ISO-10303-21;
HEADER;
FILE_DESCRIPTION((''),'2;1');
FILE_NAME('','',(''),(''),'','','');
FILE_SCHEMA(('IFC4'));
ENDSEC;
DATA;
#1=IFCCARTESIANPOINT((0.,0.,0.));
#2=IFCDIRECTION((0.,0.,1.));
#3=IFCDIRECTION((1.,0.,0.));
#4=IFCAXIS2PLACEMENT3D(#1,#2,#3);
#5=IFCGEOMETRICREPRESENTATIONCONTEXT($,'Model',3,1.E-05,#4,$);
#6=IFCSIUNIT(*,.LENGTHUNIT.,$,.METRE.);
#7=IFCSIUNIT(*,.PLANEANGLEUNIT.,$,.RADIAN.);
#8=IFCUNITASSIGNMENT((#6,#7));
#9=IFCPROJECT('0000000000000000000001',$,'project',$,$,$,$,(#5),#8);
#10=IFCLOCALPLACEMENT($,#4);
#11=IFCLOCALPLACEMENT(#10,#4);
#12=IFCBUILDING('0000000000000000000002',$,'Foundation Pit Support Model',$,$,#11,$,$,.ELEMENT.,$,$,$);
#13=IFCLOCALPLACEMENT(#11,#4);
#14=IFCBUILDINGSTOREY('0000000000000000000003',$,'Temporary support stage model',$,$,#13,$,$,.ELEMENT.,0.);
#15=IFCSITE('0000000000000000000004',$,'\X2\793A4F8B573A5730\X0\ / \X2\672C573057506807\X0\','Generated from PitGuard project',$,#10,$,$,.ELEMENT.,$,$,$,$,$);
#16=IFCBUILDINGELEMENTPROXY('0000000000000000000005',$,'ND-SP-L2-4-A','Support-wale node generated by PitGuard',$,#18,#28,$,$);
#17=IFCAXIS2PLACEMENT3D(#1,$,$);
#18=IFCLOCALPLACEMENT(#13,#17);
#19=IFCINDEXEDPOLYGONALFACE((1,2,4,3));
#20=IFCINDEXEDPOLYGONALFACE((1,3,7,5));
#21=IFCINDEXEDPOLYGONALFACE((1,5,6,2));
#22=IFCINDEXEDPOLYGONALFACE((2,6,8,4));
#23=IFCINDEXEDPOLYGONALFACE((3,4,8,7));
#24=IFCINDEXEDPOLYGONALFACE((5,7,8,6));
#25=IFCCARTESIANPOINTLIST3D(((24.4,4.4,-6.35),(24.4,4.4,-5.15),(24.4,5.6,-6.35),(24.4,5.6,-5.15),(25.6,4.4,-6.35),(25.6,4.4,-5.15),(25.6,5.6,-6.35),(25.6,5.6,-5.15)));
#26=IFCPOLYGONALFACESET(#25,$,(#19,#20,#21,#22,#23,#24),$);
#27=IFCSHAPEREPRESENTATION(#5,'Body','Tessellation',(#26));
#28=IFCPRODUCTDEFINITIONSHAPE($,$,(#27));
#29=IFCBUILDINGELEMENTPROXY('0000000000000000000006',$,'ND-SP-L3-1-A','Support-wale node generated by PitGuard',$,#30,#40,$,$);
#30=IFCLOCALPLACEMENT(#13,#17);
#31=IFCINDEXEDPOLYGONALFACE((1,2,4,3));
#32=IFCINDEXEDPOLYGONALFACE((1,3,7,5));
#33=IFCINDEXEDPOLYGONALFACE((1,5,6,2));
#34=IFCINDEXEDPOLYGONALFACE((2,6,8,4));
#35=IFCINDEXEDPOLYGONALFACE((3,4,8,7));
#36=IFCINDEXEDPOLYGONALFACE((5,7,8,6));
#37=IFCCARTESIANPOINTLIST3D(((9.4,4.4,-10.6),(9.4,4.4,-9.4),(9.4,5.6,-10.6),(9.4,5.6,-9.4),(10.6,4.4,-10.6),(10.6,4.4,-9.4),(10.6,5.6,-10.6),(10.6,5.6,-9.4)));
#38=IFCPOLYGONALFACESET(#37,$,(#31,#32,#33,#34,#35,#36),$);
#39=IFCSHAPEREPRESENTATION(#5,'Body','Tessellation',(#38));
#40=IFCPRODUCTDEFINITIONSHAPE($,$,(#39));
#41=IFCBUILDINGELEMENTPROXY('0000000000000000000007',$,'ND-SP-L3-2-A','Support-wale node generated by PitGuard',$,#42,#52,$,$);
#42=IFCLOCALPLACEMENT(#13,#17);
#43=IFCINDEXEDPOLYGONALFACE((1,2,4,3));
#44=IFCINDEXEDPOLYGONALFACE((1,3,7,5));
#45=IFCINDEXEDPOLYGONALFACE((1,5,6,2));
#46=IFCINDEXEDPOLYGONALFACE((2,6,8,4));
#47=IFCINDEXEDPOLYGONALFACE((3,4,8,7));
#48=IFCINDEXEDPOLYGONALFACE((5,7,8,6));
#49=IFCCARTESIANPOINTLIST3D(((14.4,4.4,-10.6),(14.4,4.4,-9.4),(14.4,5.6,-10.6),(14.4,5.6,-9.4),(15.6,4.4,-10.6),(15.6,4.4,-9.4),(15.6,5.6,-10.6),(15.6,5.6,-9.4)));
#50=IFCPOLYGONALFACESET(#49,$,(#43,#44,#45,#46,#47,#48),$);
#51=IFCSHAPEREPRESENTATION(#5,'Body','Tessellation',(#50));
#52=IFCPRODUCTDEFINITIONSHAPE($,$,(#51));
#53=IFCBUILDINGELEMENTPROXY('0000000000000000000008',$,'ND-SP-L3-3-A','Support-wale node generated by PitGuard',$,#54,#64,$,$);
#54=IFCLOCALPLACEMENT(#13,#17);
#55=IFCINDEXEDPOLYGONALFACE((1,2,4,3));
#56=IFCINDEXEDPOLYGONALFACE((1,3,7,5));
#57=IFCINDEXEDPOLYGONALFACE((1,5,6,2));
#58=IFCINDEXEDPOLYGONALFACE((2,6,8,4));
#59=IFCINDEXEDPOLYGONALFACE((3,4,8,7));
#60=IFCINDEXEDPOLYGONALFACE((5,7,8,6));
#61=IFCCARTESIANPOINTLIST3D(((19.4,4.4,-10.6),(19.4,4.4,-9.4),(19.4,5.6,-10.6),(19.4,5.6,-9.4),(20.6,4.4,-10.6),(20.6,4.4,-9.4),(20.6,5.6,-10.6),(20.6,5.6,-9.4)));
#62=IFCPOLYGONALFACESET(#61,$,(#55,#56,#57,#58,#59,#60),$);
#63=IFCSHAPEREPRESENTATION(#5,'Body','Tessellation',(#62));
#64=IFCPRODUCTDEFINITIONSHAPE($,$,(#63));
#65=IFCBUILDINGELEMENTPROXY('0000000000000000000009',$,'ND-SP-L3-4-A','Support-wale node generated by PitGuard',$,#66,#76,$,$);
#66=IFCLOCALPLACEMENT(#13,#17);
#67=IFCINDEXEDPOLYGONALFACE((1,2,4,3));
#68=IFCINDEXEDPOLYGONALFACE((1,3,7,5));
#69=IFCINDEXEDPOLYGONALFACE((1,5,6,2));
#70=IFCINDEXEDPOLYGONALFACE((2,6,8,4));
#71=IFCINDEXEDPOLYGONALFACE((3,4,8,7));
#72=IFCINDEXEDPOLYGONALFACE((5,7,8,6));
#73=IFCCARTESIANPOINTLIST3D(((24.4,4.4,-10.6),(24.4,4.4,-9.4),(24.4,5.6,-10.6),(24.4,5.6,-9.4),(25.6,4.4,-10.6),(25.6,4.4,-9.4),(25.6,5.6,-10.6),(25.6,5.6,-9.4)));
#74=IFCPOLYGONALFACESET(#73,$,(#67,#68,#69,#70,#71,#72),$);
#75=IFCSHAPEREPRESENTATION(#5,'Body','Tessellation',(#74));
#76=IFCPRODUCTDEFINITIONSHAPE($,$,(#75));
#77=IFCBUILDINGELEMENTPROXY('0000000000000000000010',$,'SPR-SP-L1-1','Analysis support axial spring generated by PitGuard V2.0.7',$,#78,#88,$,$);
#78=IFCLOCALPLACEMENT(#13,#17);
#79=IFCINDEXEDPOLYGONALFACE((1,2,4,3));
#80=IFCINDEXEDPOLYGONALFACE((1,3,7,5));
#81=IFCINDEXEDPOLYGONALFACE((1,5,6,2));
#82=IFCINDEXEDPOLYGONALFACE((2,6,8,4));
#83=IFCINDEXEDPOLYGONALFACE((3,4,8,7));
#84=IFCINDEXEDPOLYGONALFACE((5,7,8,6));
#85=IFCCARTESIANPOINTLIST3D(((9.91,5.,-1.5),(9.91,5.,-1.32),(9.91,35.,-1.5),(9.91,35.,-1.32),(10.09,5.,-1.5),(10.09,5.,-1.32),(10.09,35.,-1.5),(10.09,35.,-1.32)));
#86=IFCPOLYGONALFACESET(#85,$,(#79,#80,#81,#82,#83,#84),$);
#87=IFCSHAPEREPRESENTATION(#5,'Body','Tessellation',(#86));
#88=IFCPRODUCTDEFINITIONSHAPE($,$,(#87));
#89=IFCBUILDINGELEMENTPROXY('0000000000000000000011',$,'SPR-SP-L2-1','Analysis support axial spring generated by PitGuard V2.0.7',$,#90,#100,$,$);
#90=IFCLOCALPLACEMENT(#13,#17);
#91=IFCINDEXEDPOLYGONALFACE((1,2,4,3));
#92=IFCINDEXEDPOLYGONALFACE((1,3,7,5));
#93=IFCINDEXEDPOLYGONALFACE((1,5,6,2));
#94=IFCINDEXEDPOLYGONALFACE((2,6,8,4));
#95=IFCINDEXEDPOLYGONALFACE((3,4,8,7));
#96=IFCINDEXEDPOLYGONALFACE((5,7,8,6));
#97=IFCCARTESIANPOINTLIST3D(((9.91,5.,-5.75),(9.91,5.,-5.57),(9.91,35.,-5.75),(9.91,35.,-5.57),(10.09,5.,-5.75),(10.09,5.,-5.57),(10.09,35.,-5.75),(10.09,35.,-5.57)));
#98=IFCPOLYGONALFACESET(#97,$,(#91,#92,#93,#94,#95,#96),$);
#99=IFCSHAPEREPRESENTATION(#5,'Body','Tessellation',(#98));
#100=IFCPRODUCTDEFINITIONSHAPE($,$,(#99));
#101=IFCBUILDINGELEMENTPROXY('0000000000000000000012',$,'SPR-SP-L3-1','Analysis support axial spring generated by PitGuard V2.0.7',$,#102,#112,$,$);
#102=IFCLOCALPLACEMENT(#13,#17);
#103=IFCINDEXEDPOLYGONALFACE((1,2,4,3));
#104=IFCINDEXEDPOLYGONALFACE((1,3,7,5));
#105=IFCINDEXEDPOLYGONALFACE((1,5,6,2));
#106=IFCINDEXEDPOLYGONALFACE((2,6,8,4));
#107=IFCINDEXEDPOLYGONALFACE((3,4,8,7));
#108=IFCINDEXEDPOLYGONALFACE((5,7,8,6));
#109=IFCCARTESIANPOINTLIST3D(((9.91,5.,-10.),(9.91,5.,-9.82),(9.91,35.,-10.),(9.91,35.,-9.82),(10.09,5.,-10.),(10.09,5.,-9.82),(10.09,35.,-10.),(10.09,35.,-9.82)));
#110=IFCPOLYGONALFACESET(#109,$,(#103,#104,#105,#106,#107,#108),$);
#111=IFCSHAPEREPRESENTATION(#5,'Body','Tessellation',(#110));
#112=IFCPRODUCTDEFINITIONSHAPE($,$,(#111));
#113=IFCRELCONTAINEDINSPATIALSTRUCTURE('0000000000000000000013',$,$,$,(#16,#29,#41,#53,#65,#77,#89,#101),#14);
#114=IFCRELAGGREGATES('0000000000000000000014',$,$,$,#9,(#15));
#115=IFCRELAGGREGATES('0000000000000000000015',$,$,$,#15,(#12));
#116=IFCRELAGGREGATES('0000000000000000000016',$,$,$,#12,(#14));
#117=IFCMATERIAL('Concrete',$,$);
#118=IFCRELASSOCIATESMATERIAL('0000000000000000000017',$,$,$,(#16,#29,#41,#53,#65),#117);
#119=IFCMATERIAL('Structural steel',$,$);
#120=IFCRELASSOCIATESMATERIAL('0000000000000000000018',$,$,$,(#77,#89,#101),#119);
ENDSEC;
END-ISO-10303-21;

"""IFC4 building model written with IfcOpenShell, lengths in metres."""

from ifc_helpers import new_model, si_unit, frame, origin_with_axes, origin_2d, place, context, project, spatial, rectangle, extrude, material, element, save


model = new_model("IFC4")

# Units and contexts
model_context = context("Model", 3, precision=1e-05, world=origin_with_axes())
ifc_project = project(units=[si_unit("LENGTHUNIT", "METRE"), si_unit("PLANEANGLEUNIT", "RADIAN")], contexts=[model_context])

# Site, building, storey
site_placement = place(None, origin_with_axes())
site = spatial("IfcSite", under=ifc_project, at=site_placement, Name="示例场地 / 本地坐标", Description="Generated from PitGuard project", CompositionType="ELEMENT")
building_placement = place(site_placement, origin_with_axes())
building = spatial("IfcBuilding", under=site, at=building_placement, Name="Foundation Pit Support Model", CompositionType="ELEMENT")
storey_placement = place(building_placement, origin_with_axes())
storey = spatial("IfcBuildingStorey", under=building, at=storey_placement, Name="Temporary support stage model", CompositionType="ELEMENT", Elevation=0.0)

# Shared definitions
ifc_material_1 = material(Name="Structural steel")

# Shared definitions
ifc_material_2 = material(Name="Concrete")

# Building element proxies
for number, where, z_axis, x_axis, name in (
    (1, (25.0, 5.0, -6.35), (0.0, 0.0, 1.0), (1.0, 0.0, 0.0), "ND-SP-L2-4-A"),
    (2, (10.0, 5.0, -10.6), (0.0, 0.0, 1.0), (1.0, 0.0, 0.0), "ND-SP-L3-1-A"),
    (3, (15.0, 5.0, -10.6), (0.0, 0.0, 1.0), (1.0, 0.0, 0.0), "ND-SP-L3-2-A"),
    (4, (20.0, 5.0, -10.6), (0.0, 0.0, 1.0), (1.0, 0.0, 0.0), "ND-SP-L3-3-A"),
    (5, (25.0, 5.0, -10.6), (0.0, 0.0, 1.0), (1.0, 0.0, 0.0), "ND-SP-L3-4-A"),
):
    element("IfcBuildingElementProxy", number, at=place(storey_placement, frame(where, z_axis=z_axis, x_axis=x_axis)), inside=storey, material=ifc_material_2, Name=name, Description="Support-wale node generated by PitGuard", context=model_context, shape_type="SweptSolid", body=[
        extrude(rectangle(XDim=1.2, YDim=1.2, at=origin_2d()), origin_with_axes(), (0.0, 0.0, 1.0), 1.2),
    ])
for number, where, z_axis, x_axis, name in (
    (6, (10.0, 20.0, -1.5), (0.0, 0.0, 1.0), (0.0, 1.0, 0.0), "SPR-SP-L1-1"),
    (7, (10.0, 20.0, -5.75), (0.0, 0.0, 1.0), (0.0, 1.0, 0.0), "SPR-SP-L2-1"),
    (8, (10.0, 20.0, -10.0), (0.0, 0.0, 1.0), (0.0, 1.0, 0.0), "SPR-SP-L3-1"),
):
    element("IfcBuildingElementProxy", number, at=place(storey_placement, frame(where, z_axis=z_axis, x_axis=x_axis)), inside=storey, material=ifc_material_1, Name=name, Description="Analysis support axial spring generated by PitGuard V2.0.7", context=model_context, shape_type="SweptSolid", body=[
        extrude(rectangle(XDim=30.0, YDim=0.18, at=origin_2d()), origin_with_axes(), (0.0, 0.0, 1.0), 0.18),
    ])

save(model, "model.ifc")
